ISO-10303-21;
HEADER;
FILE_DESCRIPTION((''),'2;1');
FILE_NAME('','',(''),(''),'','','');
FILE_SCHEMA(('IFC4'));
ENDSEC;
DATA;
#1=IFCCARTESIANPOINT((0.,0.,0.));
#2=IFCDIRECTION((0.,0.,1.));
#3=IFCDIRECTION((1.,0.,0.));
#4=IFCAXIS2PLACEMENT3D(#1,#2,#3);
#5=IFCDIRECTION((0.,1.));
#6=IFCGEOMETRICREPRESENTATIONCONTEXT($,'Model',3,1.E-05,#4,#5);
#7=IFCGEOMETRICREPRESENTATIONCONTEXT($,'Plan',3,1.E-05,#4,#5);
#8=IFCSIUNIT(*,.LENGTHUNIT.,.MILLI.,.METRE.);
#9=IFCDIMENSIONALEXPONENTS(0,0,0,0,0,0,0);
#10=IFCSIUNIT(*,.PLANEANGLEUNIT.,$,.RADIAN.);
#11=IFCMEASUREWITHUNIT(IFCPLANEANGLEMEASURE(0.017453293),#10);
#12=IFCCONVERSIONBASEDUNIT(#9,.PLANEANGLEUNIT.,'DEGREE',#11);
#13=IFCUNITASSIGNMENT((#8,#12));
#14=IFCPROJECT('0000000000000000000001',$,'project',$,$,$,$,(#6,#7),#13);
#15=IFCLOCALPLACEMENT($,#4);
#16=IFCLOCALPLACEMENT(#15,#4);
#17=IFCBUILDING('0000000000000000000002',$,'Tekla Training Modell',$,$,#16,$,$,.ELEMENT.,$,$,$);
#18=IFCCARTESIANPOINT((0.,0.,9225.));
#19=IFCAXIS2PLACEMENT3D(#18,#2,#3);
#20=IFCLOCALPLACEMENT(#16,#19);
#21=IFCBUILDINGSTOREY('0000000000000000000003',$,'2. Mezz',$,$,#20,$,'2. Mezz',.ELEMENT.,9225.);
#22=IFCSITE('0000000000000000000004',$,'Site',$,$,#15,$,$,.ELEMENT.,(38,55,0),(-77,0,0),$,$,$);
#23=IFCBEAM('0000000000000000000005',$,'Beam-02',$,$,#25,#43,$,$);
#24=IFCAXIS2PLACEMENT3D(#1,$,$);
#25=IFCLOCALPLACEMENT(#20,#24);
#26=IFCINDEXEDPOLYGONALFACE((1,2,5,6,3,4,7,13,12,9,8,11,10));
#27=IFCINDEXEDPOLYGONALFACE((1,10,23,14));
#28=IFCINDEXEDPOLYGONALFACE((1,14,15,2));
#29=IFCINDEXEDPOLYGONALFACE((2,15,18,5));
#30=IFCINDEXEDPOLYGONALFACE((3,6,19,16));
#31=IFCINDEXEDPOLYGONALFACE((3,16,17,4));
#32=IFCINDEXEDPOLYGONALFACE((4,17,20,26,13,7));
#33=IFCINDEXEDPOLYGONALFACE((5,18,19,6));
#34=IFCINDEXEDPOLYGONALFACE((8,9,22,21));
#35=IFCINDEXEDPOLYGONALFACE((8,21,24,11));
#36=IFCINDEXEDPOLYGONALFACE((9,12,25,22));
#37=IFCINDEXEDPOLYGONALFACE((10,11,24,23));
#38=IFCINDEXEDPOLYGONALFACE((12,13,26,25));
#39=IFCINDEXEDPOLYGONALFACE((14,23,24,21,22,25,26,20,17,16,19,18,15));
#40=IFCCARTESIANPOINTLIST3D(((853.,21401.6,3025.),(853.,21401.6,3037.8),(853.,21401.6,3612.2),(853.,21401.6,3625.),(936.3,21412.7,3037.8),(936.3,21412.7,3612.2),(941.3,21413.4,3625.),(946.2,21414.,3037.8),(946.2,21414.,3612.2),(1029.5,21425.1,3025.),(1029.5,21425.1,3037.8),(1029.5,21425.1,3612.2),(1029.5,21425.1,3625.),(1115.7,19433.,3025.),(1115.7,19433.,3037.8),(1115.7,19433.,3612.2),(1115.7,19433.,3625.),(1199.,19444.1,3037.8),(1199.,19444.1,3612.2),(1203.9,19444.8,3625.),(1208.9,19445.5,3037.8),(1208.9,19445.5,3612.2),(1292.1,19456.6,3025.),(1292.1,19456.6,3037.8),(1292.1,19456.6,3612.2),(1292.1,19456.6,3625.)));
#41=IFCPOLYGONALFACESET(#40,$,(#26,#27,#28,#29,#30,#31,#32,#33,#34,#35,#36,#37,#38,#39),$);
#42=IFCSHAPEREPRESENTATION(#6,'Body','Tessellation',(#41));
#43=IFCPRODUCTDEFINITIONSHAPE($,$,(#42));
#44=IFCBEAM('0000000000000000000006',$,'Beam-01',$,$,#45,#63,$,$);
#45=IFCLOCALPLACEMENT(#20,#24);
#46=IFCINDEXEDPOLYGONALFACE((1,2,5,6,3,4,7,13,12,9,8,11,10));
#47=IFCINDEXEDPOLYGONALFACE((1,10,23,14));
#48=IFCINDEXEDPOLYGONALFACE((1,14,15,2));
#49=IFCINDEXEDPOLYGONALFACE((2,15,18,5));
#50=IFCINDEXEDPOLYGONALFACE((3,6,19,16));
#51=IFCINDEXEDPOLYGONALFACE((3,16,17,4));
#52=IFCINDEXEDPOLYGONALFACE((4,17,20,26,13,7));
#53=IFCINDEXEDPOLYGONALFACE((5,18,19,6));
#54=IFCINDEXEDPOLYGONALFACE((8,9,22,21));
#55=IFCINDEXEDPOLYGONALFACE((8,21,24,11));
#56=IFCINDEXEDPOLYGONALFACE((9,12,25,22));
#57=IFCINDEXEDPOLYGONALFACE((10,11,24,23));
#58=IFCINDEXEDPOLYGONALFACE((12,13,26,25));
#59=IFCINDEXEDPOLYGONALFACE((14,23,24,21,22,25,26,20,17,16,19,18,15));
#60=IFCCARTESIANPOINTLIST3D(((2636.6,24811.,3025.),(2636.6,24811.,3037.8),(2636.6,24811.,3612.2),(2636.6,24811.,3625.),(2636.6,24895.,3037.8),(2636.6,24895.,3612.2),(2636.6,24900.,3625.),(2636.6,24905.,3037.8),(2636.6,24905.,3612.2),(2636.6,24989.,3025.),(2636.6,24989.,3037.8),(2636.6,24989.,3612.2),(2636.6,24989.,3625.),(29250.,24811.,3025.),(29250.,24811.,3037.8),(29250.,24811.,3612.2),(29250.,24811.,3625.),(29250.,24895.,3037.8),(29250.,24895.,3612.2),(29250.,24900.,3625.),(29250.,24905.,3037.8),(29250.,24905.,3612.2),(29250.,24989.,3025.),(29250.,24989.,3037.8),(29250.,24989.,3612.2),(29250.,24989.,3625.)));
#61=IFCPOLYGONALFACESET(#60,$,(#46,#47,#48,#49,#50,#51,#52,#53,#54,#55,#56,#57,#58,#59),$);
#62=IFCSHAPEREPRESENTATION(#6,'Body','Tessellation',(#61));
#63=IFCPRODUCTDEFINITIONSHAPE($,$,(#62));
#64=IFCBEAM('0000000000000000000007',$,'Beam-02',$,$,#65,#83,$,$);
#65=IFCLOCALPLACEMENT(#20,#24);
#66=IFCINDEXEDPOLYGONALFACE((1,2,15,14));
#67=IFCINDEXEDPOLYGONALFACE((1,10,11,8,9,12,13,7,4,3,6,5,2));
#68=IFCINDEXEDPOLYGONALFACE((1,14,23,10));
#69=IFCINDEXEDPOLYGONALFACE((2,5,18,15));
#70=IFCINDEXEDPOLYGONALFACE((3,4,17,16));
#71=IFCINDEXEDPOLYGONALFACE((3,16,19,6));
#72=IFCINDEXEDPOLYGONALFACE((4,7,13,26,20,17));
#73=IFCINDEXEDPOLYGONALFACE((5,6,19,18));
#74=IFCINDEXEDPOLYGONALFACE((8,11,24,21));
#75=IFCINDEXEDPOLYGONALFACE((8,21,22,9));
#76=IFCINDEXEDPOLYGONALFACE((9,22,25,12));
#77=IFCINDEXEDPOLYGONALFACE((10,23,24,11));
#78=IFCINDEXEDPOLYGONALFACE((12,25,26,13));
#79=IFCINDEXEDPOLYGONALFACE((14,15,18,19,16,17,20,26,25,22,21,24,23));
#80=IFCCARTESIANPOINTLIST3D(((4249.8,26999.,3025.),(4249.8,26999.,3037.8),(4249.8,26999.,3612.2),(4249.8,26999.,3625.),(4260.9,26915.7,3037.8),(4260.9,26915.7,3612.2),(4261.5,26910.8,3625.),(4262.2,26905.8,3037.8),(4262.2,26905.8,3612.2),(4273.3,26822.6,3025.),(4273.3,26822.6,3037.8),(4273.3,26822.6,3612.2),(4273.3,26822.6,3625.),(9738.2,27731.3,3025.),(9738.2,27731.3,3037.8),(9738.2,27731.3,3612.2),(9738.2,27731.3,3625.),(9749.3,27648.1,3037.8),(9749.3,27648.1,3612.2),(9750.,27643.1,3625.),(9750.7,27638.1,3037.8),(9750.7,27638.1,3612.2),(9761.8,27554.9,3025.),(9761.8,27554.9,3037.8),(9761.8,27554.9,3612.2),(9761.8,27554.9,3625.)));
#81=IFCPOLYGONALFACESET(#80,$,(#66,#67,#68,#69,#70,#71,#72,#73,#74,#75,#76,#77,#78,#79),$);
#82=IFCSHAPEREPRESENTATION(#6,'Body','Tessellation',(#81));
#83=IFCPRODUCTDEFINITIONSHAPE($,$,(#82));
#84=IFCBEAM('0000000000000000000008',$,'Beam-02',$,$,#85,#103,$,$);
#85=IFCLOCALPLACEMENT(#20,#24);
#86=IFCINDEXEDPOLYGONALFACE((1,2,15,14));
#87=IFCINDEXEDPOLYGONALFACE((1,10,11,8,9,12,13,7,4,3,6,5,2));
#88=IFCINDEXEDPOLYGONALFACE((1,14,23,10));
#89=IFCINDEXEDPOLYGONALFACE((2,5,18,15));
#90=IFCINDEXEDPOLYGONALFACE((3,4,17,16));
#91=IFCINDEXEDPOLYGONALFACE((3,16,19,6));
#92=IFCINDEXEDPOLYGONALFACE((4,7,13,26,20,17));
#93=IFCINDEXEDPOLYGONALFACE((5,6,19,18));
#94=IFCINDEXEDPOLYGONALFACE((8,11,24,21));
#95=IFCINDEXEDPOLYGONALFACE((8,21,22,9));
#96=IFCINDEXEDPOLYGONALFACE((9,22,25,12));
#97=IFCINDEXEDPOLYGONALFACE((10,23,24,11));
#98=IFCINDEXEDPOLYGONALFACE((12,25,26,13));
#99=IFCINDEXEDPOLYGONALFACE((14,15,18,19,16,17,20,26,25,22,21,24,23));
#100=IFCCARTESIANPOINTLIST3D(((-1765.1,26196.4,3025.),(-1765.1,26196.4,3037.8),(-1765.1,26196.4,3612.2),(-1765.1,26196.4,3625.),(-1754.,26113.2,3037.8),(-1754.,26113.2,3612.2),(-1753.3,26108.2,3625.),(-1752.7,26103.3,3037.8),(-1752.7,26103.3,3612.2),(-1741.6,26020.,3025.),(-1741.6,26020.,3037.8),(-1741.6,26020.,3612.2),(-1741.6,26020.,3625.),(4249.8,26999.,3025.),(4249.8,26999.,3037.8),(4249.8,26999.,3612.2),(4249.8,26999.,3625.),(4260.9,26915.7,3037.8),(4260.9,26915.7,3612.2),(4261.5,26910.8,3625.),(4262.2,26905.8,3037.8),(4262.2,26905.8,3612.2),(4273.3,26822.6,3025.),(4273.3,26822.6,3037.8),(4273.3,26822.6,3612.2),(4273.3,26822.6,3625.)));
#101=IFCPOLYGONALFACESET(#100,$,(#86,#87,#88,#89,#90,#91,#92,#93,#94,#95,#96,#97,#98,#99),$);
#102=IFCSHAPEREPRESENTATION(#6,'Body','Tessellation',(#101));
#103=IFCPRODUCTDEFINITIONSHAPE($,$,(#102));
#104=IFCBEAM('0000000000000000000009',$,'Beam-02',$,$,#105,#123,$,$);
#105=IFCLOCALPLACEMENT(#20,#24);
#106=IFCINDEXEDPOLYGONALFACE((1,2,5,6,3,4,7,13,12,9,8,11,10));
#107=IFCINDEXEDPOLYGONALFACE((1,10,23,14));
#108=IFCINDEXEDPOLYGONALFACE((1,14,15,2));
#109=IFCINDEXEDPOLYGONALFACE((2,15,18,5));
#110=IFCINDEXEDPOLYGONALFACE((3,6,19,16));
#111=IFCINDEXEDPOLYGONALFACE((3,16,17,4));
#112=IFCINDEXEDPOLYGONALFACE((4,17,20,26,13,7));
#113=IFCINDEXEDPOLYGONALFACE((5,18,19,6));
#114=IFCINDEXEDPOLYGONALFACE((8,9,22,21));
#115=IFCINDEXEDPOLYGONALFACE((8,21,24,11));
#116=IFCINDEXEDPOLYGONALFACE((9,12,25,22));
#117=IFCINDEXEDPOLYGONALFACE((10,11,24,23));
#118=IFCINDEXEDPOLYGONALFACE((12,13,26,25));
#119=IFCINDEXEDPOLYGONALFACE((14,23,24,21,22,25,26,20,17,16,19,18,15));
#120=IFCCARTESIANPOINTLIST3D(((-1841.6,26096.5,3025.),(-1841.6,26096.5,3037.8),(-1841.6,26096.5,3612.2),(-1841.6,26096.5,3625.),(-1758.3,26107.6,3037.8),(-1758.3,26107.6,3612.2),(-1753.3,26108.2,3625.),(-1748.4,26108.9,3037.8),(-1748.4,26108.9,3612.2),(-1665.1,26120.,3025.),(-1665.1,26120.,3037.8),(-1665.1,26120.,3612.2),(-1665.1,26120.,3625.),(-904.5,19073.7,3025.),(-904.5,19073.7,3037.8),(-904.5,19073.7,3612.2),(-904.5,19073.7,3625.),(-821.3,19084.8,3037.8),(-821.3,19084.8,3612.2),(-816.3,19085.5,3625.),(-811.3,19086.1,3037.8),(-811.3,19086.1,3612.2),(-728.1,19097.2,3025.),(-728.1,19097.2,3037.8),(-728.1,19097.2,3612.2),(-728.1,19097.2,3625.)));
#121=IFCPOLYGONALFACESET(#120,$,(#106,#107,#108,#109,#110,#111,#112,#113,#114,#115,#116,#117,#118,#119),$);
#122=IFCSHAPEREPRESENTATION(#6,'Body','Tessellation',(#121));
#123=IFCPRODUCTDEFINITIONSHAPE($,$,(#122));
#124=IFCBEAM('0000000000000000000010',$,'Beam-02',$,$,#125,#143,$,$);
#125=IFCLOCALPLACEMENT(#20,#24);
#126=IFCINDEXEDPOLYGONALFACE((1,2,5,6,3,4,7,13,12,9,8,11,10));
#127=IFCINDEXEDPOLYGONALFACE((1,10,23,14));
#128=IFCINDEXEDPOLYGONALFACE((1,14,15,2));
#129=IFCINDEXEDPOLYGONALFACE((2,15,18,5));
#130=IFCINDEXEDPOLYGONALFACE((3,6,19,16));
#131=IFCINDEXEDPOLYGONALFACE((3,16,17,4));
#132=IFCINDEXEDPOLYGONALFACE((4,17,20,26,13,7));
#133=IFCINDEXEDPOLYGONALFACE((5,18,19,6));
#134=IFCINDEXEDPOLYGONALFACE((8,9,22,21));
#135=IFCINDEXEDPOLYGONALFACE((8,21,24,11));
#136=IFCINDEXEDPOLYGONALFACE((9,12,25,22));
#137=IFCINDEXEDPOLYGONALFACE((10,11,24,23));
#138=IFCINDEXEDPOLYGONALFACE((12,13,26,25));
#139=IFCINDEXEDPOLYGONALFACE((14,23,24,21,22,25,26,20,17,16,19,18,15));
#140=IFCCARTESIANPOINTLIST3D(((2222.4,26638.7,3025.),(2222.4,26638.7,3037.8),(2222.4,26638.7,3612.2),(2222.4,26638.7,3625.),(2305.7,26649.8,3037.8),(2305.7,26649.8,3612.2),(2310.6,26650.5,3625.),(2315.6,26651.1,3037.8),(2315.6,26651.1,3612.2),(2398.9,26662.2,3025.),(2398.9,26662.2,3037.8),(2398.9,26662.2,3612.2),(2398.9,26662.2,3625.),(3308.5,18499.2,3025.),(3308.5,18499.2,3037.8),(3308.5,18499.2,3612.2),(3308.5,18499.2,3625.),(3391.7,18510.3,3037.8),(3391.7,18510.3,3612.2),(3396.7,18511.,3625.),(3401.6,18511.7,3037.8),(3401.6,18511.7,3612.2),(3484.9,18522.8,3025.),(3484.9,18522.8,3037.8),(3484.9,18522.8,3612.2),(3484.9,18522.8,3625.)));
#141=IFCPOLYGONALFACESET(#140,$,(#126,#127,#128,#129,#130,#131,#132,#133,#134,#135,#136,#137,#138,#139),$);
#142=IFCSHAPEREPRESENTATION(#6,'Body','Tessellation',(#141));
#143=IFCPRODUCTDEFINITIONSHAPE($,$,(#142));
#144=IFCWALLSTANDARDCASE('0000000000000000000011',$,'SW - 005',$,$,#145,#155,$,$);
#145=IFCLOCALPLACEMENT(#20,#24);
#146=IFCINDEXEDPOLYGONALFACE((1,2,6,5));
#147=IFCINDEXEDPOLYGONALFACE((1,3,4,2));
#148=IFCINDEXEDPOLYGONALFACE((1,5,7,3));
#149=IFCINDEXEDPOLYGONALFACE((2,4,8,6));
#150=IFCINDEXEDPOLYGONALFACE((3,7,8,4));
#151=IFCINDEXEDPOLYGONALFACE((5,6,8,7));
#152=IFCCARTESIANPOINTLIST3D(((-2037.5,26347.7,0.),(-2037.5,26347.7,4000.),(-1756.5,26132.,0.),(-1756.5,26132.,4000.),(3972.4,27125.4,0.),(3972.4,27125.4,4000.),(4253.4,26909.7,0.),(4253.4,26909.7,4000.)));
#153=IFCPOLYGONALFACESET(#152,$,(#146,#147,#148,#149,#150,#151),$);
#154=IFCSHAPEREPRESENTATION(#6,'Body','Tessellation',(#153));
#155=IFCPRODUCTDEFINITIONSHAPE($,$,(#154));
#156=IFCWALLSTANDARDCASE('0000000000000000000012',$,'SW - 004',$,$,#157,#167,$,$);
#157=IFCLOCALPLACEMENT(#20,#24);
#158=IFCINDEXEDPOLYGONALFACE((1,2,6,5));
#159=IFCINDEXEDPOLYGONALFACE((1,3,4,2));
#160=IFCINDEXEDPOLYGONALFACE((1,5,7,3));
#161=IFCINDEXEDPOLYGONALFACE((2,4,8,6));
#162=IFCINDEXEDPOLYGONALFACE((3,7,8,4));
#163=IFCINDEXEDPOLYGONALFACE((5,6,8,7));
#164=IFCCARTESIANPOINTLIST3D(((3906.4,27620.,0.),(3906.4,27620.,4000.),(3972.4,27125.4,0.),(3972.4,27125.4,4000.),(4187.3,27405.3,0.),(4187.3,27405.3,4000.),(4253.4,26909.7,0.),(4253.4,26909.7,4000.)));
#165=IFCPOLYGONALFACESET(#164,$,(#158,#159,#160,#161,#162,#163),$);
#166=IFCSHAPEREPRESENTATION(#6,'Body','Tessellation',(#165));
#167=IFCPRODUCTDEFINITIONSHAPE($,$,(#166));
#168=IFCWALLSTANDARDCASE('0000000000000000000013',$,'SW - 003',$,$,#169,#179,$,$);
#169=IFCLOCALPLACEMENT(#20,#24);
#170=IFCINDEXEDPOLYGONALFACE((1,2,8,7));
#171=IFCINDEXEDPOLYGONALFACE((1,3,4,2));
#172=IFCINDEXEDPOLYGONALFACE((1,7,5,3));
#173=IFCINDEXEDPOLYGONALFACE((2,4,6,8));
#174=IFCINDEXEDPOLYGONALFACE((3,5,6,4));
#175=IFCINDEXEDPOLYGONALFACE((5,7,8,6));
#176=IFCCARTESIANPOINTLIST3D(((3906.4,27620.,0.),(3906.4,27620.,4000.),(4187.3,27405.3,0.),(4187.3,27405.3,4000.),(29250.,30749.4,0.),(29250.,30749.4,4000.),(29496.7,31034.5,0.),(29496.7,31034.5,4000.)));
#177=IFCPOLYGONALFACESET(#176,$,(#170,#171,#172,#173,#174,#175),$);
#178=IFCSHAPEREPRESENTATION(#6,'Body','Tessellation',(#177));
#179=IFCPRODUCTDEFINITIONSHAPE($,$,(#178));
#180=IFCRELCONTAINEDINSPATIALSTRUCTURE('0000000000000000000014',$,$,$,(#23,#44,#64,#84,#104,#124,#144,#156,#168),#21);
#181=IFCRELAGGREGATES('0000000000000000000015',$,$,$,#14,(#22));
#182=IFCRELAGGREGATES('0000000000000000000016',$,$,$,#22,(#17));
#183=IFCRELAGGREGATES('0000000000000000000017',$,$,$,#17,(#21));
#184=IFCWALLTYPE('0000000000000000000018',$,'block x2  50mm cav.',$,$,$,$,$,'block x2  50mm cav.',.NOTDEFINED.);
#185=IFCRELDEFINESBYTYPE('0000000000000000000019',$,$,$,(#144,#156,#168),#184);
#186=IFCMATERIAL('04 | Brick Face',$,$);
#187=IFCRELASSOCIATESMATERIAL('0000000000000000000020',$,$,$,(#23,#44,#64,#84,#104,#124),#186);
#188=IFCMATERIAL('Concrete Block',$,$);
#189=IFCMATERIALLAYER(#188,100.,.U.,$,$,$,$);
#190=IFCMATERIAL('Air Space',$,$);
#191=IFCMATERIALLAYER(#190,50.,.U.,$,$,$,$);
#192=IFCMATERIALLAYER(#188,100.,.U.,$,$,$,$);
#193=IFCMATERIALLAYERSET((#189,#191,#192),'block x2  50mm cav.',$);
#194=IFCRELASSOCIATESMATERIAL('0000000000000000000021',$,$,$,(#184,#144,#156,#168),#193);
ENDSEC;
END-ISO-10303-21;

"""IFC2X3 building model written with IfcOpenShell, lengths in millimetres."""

from ifc_helpers import new_model, entity, si_unit, converted_unit, direction, frame, origin_with_axes, place, context, project, spatial, polyline, outline, extrude, material, layer, layer_set, layer_usage, type_object, element, save


model = new_model("IFC2X3")

# Units and contexts
model_context = context("Model", 3, precision=1e-05, world=origin_with_axes(), true_north=direction((0.0, 1.0)))
plan_context = context("Plan", 3, precision=1e-05, world=origin_with_axes(), true_north=direction((0.0, 1.0)))
ifc_project = project(units=[si_unit("LENGTHUNIT", "METRE", prefix="MILLI"), converted_unit("PLANEANGLEUNIT", "DEGREE", entity("IfcPlaneAngleMeasure", 0.017453293), si_unit("PLANEANGLEUNIT", "RADIAN"), dimensions=[0, 0, 0, 0, 0, 0, 0])], contexts=[model_context, plan_context])

# Site, building, storey
site_placement = place(None, origin_with_axes())
site = spatial("IfcSite", under=ifc_project, at=site_placement, Name="Site", CompositionType="ELEMENT", RefLatitude=(38, 55, 0), RefLongitude=(-77, 0, 0))
building_placement = place(site_placement, origin_with_axes())
building = spatial("IfcBuilding", under=site, at=building_placement, Name="Tekla Training Modell", CompositionType="ELEMENT")
storey_placement = place(building_placement, frame((0.0, 0.0, 9225.0), z_axis=(0.0, 0.0, 1.0), x_axis=(1.0, 0.0, 0.0)))
storey = spatial("IfcBuildingStorey", under=building, at=storey_placement, Name="2. Mezz", LongName="2. Mezz", CompositionType="ELEMENT", Elevation=9225.0)

# Shared definitions
ifc_material_1 = material(Name="04 | Brick Face")

# Beams
beam_1_placement = place(storey_placement, frame((941.3, 21413.4, 3325.0), z_axis=(0.0, 0.0, 1.0), x_axis=(-0.991216, -0.132256, 0.0)))
element("IfcBeam", 1, at=beam_1_placement, inside=storey, material=ifc_material_1, Name="Beam-02", context=model_context, shape_type="SweptSolid", body=[
    extrude(outline(polyline([(0.0, 300.0), (-89.0, 300.0), (-89.0, 287.2), (-5.0, 287.2), (-5.0, -287.2), (-89.0, -287.2), (-89.0, -300.0), (89.0, -300.0), (89.0, -287.2), (5.0, -287.2), (5.0, 287.2), (89.0, 287.2), (89.0, 300.0), (0.0, 300.0)])), frame((0.0, 1986.0, 0.0), z_axis=(0.0, -1.0, 0.0), x_axis=(1.0, 0.0, 0.0)), (0.0, 0.0, 1.0), 1986.0),
])
beam_2_placement = place(storey_placement, frame((2636.6, 24900.0, 3325.0), z_axis=(0.0, 0.0, 1.0), x_axis=(0.0, -1.0, 0.0)))
element("IfcBeam", 2, at=beam_2_placement, inside=storey, material=ifc_material_1, Name="Beam-01", context=model_context, shape_type="SweptSolid", body=[
    extrude(outline(polyline([(0.0, 300.0), (-89.0, 300.0), (-89.0, 287.2), (-5.0, 287.2), (-5.0, -287.2), (-89.0, -287.2), (-89.0, -300.0), (89.0, -300.0), (89.0, -287.2), (5.0, -287.2), (5.0, 287.2), (89.0, 287.2), (89.0, 300.0), (0.0, 300.0)])), frame((0.0, 26613.4, 0.0), z_axis=(0.0, -1.0, 0.0), x_axis=(1.0, 0.0, 0.0)), (0.0, 0.0, 1.0), 26613.4),
])
beam_3_placement = place(storey_placement, frame((4261.5, 26910.8, 3325.0), z_axis=(0.0, 0.0, 1.0), x_axis=(0.132256, -0.991216, 0.0)))
element("IfcBeam", 3, at=beam_3_placement, inside=storey, material=ifc_material_1, Name="Beam-02", context=model_context, shape_type="SweptSolid", body=[
    extrude(outline(polyline([(0.0, 300.0), (-89.0, 300.0), (-89.0, 287.2), (-5.0, 287.2), (-5.0, -287.2), (-89.0, -287.2), (-89.0, -300.0), (89.0, -300.0), (89.0, -287.2), (5.0, -287.2), (5.0, 287.2), (89.0, 287.2), (89.0, 300.0), (0.0, 300.0)])), frame((0.0, 5537.1, 0.0), z_axis=(0.0, -1.0, 0.0), x_axis=(1.0, 0.0, 0.0)), (0.0, 0.0, 1.0), 5537.1),
])
beam_4_placement = place(storey_placement, frame((-1753.3, 26108.2, 3325.0), z_axis=(0.0, 0.0, 1.0), x_axis=(0.132256, -0.991216, 0.0)))
element("IfcBeam", 4, at=beam_4_placement, inside=storey, material=ifc_material_1, Name="Beam-02", context=model_context, shape_type="SweptSolid", body=[
    extrude(outline(polyline([(0.0, 300.0), (-89.0, 300.0), (-89.0, 287.2), (-5.0, 287.2), (-5.0, -287.2), (-89.0, -287.2), (-89.0, -300.0), (89.0, -300.0), (89.0, -287.2), (5.0, -287.2), (5.0, 287.2), (89.0, 287.2), (89.0, 300.0), (0.0, 300.0)])), frame((0.0, 6068.2, 0.0), z_axis=(0.0, -1.0, 0.0), x_axis=(1.0, 0.0, 0.0)), (0.0, 0.0, 1.0), 6068.2),
])
beam_5_placement = place(storey_placement, frame((-1753.3, 26108.2, 3325.0), z_axis=(0.0, 0.0, 1.0), x_axis=(-0.991216, -0.132256, 0.0)))
element("IfcBeam", 5, at=beam_5_placement, inside=storey, material=ifc_material_1, Name="Beam-02", context=model_context, shape_type="SweptSolid", body=[
    extrude(outline(polyline([(0.0, 300.0), (-89.0, 300.0), (-89.0, 287.2), (-5.0, 287.2), (-5.0, -287.2), (-89.0, -287.2), (-89.0, -300.0), (89.0, -300.0), (89.0, -287.2), (5.0, -287.2), (5.0, 287.2), (89.0, 287.2), (89.0, 300.0), (0.0, 300.0)])), frame((0.0, 7085.0, 0.0), z_axis=(0.0, -1.0, 0.0), x_axis=(1.0, 0.0, 0.0)), (0.0, 0.0, 1.0), 7085.0),
])
beam_6_placement = place(storey_placement, frame((2310.6, 26650.5, 3325.0), z_axis=(0.0, 0.0, 1.0), x_axis=(-0.991216, -0.132256, 0.0)))
element("IfcBeam", 6, at=beam_6_placement, inside=storey, material=ifc_material_1, Name="Beam-02", context=model_context, shape_type="SweptSolid", body=[
    extrude(outline(polyline([(0.0, 300.0), (-89.0, 300.0), (-89.0, 287.2), (-5.0, 287.2), (-5.0, -287.2), (-89.0, -287.2), (-89.0, -300.0), (89.0, -300.0), (89.0, -287.2), (5.0, -287.2), (5.0, 287.2), (89.0, 287.2), (89.0, 300.0), (0.0, 300.0)])), frame((0.0, 8211.6, 0.0), z_axis=(0.0, -1.0, 0.0), x_axis=(1.0, 0.0, 0.0)), (0.0, 0.0, 1.0), 8211.6),
])

# Walls
ifc_material_2 = material(Name="Concrete Block")
ifc_layer_1 = layer(ifc_material_2, 100.0, ventilated="UNKNOWN")
ifc_material_3 = material(Name="Air Space")
ifc_layer_2 = layer(ifc_material_3, 50.0, ventilated="UNKNOWN")
ifc_layer_3 = layer(ifc_material_2, 100.0, ventilated="UNKNOWN")
ifc_layer_set_1 = layer_set([ifc_layer_1, ifc_layer_2, ifc_layer_3], Name="block x2  50mm cav.")
ifc_layer_usage_1 = layer_usage(ifc_layer_set_1, "AXIS2", "NEGATIVE", 0.0)
wall_type = type_object("IfcWallType", Name="block x2  50mm cav.", ElementType="block x2  50mm cav.", PredefinedType="NOTDEFINED", material=ifc_layer_set_1)
wall_1_placement = place(storey_placement, frame((4253.4, 26909.7, 0.0), z_axis=(0.0, 0.0, 1.0), x_axis=(-0.991732, -0.12833, 0.0)))
element("IfcWallStandardCase", 7, at=wall_1_placement, inside=storey, type_object=wall_type, material=ifc_layer_usage_1, Name="SW - 005", context=model_context, shape_type="SweptSolid", body=[
    extrude(outline(polyline([(251.0, -250.0), (6311.0, -250.0), (6060.0, 0.0), (0.0, 0.0), (251.0, -250.0)])), origin_with_axes(), (0.0, 0.0, 1.0), 4000.0),
])
ifc_layer_usage_2 = layer_usage(ifc_layer_set_1, "AXIS2", "NEGATIVE", 0.0)
wall_2_placement = place(storey_placement, frame((4187.3, 27405.3, 0.0), z_axis=(0.0, 0.0, 1.0), x_axis=(0.132257, -0.991215, 0.0)))
element("IfcWallStandardCase", 8, at=wall_2_placement, inside=storey, type_object=wall_type, material=ifc_layer_usage_2, Name="SW - 004", context=model_context, shape_type="SweptSolid", body=[
    extrude(outline(polyline([(-250.0, -250.0), (249.0, -250.0), (500.0, 0.0), (0.0, 0.0), (-250.0, -250.0)])), origin_with_axes(), (0.0, 0.0, 1.0), 4000.0),
])
ifc_layer_usage_3 = layer_usage(ifc_layer_set_1, "AXIS2", "NEGATIVE", 0.0)
wall_3_placement = place(storey_placement, frame((29250.0, 30749.4, 0.0), z_axis=(0.0, 0.0, 1.0), x_axis=(-0.991216, -0.132256, 0.0)))
element("IfcWallStandardCase", 9, at=wall_3_placement, inside=storey, type_object=wall_type, material=ifc_layer_usage_3, Name="SW - 003", context=model_context, shape_type="SweptSolid", body=[
    extrude(outline(polyline([(-282.2, -250.0), (25534.8, -250.0), (25284.8, 0.0), (0.0, 0.0), (-282.2, -250.0)])), origin_with_axes(), (0.0, 0.0, 1.0), 4000.0),
])

save(model, "model.ifc")
